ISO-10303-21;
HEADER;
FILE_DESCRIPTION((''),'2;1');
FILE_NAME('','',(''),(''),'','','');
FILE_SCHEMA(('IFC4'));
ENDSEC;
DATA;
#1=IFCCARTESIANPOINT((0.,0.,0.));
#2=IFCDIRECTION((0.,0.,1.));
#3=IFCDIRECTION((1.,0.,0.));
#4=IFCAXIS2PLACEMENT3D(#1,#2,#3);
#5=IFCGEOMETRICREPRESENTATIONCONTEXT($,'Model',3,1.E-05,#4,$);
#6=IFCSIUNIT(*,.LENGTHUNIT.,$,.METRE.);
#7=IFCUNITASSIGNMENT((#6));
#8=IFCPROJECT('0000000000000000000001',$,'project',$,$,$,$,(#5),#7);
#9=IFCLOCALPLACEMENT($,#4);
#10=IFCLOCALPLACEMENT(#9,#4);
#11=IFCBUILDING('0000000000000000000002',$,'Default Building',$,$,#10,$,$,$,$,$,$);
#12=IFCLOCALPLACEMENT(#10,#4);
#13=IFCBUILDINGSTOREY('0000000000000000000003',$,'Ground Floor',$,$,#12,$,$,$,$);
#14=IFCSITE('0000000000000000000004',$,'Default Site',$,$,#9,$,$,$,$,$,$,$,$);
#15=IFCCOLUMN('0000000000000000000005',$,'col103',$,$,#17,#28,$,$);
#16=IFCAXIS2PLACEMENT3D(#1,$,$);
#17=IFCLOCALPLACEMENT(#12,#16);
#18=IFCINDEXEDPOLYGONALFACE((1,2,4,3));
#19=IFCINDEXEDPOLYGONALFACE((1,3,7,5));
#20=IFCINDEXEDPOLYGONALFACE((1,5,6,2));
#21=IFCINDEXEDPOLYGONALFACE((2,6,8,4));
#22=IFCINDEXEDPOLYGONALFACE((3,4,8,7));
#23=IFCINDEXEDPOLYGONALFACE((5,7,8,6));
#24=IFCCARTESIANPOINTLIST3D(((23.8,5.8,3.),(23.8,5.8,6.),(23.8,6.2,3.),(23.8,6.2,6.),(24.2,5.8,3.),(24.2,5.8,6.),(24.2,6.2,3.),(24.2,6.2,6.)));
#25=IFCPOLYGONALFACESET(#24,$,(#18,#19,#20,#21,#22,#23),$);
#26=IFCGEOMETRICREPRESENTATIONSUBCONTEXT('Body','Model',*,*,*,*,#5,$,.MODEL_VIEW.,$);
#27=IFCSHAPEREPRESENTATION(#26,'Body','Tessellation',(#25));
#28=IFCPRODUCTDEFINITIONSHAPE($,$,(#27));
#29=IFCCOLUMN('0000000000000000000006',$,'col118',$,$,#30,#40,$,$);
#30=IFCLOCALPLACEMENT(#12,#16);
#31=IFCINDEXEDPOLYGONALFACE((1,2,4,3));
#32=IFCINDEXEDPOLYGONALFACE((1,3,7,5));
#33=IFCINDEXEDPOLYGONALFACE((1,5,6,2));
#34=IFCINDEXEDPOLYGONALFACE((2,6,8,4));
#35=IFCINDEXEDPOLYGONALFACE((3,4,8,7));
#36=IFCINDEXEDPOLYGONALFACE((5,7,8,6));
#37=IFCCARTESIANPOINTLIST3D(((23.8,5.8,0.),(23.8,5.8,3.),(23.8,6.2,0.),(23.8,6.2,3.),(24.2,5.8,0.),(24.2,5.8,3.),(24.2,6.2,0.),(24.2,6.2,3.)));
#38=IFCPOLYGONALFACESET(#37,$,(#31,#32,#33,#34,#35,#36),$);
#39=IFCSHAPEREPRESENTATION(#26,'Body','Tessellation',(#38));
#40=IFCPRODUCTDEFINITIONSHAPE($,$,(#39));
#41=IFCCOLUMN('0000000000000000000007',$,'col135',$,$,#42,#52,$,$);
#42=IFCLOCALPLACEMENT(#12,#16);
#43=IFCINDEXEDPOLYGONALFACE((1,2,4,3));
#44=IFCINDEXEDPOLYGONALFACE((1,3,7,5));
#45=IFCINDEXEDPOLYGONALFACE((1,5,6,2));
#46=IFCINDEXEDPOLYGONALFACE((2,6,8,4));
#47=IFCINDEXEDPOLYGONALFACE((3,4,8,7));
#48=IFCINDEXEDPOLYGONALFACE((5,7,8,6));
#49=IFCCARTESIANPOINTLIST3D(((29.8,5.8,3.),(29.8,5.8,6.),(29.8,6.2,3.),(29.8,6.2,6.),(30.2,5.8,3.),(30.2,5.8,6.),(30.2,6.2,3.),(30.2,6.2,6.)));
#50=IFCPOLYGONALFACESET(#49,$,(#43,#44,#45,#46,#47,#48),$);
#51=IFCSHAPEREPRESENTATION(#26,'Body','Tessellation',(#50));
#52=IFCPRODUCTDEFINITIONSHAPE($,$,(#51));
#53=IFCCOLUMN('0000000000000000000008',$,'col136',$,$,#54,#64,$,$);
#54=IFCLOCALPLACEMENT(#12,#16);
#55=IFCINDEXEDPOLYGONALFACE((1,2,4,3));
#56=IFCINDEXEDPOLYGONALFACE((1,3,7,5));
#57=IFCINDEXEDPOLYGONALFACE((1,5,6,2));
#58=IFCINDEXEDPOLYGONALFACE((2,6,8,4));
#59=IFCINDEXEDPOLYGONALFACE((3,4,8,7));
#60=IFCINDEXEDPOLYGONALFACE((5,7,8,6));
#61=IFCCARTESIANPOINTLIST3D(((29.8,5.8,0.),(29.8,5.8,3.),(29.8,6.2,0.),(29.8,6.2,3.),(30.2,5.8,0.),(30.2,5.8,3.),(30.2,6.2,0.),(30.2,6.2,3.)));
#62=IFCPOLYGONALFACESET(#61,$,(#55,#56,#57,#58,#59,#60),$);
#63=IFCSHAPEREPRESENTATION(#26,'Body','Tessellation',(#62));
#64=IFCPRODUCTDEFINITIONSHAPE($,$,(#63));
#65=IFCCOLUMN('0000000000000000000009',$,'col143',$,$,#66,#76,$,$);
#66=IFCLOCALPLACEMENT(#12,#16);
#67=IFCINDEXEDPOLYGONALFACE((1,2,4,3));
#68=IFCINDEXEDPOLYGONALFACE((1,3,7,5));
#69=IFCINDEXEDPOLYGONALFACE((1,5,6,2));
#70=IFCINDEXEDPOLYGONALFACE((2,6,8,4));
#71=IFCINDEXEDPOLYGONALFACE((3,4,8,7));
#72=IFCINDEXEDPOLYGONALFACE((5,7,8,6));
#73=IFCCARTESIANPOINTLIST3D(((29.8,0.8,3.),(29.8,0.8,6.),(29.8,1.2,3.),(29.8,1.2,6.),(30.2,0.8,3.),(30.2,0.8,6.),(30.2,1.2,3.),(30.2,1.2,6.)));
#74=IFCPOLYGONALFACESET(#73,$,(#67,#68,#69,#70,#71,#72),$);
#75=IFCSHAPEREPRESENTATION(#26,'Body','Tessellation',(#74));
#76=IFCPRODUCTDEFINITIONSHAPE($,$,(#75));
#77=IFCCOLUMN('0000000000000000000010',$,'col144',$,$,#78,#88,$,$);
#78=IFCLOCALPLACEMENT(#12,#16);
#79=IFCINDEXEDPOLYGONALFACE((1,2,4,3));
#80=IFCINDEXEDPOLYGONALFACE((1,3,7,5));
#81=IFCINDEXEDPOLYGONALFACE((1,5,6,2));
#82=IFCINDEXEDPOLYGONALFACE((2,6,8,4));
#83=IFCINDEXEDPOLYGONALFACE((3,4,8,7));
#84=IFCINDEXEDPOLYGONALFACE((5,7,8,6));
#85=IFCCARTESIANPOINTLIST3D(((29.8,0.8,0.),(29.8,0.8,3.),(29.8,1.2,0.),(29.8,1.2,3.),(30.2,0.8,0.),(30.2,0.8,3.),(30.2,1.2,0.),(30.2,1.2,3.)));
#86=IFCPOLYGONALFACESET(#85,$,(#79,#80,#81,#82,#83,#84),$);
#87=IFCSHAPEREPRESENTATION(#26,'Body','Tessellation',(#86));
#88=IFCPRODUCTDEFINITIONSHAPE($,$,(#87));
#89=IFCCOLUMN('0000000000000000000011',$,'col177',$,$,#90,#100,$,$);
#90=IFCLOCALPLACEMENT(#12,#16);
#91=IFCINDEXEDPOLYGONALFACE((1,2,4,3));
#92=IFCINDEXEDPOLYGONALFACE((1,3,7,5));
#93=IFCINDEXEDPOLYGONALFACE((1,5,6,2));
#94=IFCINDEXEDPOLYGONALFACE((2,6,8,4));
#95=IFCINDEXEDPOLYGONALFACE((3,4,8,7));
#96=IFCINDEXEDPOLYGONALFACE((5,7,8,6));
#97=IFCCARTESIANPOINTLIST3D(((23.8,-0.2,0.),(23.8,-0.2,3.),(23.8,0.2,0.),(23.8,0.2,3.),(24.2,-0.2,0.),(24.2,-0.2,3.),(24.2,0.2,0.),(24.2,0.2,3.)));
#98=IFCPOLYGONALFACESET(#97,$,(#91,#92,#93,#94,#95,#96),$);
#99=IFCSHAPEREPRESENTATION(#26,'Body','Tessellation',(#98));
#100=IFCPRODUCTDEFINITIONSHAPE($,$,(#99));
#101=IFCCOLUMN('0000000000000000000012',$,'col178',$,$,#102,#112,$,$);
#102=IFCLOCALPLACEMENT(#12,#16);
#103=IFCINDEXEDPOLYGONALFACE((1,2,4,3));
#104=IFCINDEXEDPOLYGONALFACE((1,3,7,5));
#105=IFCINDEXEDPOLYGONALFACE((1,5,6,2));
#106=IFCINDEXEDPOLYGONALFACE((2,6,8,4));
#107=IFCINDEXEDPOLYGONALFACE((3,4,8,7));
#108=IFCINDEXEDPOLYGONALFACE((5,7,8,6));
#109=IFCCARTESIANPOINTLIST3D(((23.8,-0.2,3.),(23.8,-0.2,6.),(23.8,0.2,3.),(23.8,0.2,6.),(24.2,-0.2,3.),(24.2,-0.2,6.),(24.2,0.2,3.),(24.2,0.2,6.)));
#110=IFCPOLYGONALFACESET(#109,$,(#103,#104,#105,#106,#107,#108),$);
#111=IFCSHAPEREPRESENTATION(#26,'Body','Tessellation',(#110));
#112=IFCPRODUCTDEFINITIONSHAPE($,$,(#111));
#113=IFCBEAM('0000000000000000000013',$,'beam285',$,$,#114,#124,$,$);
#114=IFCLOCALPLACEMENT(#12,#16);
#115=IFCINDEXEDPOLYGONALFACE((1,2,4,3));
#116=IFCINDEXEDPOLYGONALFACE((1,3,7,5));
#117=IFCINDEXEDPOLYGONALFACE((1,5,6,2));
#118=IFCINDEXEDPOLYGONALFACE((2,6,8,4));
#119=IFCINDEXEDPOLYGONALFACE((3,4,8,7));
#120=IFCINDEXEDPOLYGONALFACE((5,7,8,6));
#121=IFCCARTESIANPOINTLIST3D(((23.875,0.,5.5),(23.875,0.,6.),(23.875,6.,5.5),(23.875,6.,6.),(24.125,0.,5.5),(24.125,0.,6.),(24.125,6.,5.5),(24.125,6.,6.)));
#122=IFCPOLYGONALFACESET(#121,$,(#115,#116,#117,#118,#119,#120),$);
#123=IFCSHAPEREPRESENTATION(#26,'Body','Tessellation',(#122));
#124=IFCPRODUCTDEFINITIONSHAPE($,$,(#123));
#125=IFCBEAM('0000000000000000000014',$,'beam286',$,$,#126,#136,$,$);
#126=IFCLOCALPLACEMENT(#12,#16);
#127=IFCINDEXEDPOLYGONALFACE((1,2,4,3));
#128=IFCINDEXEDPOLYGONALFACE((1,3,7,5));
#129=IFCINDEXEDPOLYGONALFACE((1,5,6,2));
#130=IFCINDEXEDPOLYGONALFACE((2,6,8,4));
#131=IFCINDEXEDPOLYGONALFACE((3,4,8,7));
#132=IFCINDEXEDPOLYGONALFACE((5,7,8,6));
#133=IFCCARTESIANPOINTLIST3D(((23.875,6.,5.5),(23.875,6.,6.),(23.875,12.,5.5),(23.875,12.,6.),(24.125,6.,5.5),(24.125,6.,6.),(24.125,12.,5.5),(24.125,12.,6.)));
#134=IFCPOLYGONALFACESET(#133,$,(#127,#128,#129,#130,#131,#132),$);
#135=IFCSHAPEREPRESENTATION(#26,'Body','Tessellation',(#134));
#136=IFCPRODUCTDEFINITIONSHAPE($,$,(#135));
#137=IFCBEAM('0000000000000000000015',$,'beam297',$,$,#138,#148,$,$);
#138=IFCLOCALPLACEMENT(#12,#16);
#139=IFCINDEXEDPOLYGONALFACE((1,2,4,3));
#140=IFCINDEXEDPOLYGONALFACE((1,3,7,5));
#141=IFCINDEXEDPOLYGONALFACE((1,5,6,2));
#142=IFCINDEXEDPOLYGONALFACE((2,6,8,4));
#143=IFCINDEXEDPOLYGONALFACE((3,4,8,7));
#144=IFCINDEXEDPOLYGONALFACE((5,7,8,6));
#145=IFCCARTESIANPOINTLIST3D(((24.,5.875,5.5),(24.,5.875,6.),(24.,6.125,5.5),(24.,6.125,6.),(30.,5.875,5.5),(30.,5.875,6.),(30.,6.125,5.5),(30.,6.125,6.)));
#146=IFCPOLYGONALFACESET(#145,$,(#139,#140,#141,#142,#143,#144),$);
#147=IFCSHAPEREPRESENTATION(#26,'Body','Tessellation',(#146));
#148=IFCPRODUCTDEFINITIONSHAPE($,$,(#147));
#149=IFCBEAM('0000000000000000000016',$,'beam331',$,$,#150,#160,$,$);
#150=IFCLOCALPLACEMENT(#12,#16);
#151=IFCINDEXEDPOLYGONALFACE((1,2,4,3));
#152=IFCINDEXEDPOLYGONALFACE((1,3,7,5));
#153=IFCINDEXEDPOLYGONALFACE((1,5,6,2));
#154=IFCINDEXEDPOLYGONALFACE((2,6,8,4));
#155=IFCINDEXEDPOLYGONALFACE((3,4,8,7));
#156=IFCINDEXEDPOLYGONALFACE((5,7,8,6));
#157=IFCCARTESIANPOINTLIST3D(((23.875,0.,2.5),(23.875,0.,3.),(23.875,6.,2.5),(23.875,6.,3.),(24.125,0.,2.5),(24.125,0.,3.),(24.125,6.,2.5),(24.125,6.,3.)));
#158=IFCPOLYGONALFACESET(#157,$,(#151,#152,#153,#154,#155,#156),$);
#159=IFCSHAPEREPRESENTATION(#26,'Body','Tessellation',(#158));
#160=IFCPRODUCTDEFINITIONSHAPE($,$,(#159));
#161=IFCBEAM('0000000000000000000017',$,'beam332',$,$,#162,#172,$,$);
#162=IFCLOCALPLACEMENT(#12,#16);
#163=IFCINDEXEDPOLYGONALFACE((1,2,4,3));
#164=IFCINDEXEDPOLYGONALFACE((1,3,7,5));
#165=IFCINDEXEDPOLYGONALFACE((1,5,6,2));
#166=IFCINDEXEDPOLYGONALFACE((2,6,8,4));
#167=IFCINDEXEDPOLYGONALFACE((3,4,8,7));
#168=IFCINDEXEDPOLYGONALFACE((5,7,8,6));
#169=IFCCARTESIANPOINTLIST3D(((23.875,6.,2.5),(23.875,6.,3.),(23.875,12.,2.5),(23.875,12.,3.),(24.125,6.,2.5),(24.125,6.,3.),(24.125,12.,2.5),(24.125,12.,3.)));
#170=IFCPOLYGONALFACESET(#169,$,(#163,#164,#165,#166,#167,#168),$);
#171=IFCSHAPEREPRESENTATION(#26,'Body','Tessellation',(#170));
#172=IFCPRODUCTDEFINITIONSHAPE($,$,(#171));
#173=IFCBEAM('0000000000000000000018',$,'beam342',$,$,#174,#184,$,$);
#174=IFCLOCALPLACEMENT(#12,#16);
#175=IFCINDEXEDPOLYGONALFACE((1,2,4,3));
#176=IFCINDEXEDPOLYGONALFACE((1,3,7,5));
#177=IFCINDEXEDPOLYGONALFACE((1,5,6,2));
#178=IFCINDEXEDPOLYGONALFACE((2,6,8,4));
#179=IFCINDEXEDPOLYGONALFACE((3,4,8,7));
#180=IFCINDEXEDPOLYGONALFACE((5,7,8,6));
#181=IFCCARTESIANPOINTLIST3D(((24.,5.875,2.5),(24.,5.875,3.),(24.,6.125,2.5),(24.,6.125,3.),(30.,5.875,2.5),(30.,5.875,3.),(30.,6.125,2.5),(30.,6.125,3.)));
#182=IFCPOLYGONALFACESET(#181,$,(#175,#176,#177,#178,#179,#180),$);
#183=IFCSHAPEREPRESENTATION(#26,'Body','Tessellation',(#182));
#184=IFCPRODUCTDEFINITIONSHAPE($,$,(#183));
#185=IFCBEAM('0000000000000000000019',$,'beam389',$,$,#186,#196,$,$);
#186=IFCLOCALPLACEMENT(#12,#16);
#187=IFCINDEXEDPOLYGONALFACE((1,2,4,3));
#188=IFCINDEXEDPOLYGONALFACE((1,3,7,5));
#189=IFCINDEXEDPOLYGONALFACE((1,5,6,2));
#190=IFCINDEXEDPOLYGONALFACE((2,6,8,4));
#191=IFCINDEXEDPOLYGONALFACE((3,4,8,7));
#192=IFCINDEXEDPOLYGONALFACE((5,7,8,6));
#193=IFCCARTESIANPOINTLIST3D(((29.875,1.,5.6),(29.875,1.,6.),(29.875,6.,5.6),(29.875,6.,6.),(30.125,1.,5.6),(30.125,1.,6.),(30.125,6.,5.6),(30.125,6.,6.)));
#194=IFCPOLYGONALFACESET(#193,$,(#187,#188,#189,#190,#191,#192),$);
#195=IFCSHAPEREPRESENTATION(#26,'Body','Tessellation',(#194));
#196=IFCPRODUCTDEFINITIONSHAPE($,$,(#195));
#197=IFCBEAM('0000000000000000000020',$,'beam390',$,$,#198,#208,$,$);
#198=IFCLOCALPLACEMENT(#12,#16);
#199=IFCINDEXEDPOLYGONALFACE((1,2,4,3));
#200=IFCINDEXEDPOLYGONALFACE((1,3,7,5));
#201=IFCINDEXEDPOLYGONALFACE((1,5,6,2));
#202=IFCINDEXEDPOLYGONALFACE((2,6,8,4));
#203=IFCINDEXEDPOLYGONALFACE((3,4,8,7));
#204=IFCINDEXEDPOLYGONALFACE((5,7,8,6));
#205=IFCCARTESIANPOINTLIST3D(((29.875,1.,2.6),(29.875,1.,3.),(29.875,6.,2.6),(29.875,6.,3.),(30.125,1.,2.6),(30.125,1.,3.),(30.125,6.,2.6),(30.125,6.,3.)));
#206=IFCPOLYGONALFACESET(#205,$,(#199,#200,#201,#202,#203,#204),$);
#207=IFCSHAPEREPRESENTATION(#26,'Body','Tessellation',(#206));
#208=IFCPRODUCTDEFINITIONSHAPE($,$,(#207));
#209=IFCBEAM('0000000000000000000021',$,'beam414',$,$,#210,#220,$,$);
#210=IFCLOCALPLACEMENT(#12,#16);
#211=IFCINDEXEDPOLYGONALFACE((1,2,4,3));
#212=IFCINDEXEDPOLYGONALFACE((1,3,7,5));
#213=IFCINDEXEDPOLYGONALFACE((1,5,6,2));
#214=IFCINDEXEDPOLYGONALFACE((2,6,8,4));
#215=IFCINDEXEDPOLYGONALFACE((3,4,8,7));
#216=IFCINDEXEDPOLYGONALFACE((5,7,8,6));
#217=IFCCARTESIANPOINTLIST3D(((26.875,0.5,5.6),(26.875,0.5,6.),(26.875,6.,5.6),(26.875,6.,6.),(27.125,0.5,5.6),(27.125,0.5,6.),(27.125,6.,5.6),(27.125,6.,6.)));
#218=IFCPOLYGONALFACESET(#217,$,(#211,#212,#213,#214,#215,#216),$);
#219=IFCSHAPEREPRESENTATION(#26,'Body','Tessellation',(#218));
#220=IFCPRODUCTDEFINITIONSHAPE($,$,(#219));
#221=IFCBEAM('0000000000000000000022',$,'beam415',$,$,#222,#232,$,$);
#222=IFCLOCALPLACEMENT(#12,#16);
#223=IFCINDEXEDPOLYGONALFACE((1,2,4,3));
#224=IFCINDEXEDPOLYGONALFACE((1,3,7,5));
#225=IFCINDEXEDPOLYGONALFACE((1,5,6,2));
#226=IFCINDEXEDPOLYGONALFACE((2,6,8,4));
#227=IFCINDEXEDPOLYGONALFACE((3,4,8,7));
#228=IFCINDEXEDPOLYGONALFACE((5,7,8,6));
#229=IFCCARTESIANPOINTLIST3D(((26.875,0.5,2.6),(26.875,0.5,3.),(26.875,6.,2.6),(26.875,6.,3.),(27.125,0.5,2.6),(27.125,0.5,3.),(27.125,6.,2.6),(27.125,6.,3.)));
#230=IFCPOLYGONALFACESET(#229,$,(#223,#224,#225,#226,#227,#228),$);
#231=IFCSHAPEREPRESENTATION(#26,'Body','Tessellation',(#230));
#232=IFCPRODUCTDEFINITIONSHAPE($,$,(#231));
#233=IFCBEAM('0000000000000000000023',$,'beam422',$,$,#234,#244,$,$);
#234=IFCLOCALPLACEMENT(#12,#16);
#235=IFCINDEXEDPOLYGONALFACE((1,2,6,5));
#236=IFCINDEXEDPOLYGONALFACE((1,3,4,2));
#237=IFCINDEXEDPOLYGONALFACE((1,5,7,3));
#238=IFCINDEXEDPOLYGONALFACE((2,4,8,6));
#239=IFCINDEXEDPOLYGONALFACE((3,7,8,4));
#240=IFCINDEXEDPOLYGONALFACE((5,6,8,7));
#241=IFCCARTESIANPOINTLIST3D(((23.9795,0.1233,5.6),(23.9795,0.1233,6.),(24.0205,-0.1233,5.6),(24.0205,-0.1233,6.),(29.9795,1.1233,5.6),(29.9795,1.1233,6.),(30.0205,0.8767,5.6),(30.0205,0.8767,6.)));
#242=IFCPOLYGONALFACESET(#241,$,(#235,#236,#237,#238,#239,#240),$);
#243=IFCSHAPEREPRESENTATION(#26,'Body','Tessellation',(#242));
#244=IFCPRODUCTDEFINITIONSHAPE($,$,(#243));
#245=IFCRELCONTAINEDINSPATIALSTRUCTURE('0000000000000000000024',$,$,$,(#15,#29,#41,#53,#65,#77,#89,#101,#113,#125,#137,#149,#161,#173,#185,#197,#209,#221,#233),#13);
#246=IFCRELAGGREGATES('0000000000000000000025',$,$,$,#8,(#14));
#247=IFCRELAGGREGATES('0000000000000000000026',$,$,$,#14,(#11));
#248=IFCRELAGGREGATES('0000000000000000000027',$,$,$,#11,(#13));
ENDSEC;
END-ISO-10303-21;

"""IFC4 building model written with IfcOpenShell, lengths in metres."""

from ifc_helpers import new_model, si_unit, frame, origin_with_axes, place, context, subcontext, project, spatial, indexed_curve, outline, extrude, element, save


model = new_model("IFC4")

# Units and contexts
model_context = context("Model", 3, precision=1e-05, world=origin_with_axes())
body_context = subcontext(model_context, "Body", "Model", "MODEL_VIEW")
ifc_project = project(units=[si_unit("LENGTHUNIT", "METRE")], contexts=[model_context])

# Site, building, storey
site_placement = place(None, origin_with_axes())
site = spatial("IfcSite", under=ifc_project, at=site_placement, Name="Default Site")
building_placement = place(site_placement, origin_with_axes())
building = spatial("IfcBuilding", under=site, at=building_placement, Name="Default Building")
storey_placement = place(building_placement, origin_with_axes())
storey = spatial("IfcBuildingStorey", under=building, at=storey_placement, Name="Ground Floor")

# Columns
for number, where, z_axis, x_axis, name in (
    (1, (23.8, 5.8, 3.0), (0.0, 0.0, 1.0), (1.0, 0.0, 0.0), "col103"),
    (2, (23.8, 5.8, 0.0), (0.0, 0.0, 1.0), (1.0, 0.0, 0.0), "col118"),
    (3, (29.8, 5.8, 3.0), (0.0, 0.0, 1.0), (1.0, 0.0, 0.0), "col135"),
    (4, (29.8, 5.8, 0.0), (0.0, 0.0, 1.0), (1.0, 0.0, 0.0), "col136"),
    (5, (29.8, 0.8, 3.0), (0.0, 0.0, 1.0), (1.0, 0.0, 0.0), "col143"),
    (6, (29.8, 0.8, 0.0), (0.0, 0.0, 1.0), (1.0, 0.0, 0.0), "col144"),
    (7, (23.8, -0.2, 0.0), (0.0, 0.0, 1.0), (1.0, 0.0, 0.0), "col177"),
    (8, (23.8, -0.2, 3.0), (0.0, 0.0, 1.0), (1.0, 0.0, 0.0), "col178"),
):
    element("IfcColumn", number, at=place(storey_placement, frame(where, z_axis=z_axis, x_axis=x_axis)), inside=storey, Name=name, context=body_context, shape_type="SweptSolid", body=[
        extrude(outline(indexed_curve([(0.0, 0.0), (0.0, 0.4), (0.4, 0.4), (0.4, 0.0), (0.0, 0.0)], self_intersect=False)), origin_with_axes(), (0.0, 0.0, 1.0), 3.0),
    ])

# Beams
for number, where, z_axis, x_axis, name in (
    (9, (24.125, 0.0, 5.5), (0.0, 0.0, 1.0), (0.0, 1.0, 0.0), "beam285"),
    (10, (24.125, 6.0, 5.5), (0.0, 0.0, 1.0), (0.0, 1.0, 0.0), "beam286"),
    (11, (24.0, 5.875, 5.5), (0.0, 0.0, 1.0), (1.0, 0.0, 0.0), "beam297"),
    (12, (24.125, 0.0, 2.5), (0.0, 0.0, 1.0), (0.0, 1.0, 0.0), "beam331"),
    (13, (24.125, 6.0, 2.5), (0.0, 0.0, 1.0), (0.0, 1.0, 0.0), "beam332"),
    (14, (24.0, 5.875, 2.5), (0.0, 0.0, 1.0), (1.0, 0.0, 0.0), "beam342"),
):
    element("IfcBeam", number, at=place(storey_placement, frame(where, z_axis=z_axis, x_axis=x_axis)), inside=storey, Name=name, context=body_context, shape_type="SweptSolid", body=[
        extrude(outline(indexed_curve([(0.0, 0.0), (0.0, 0.25), (6.0, 0.25), (6.0, 0.0), (0.0, 0.0)], self_intersect=False)), origin_with_axes(), (0.0, 0.0, 1.0), 0.5),
    ])
for number, where, z_axis, x_axis, name in (
    (15, (29.875, 6.0, 5.6), (0.0, 0.0, 1.0), (0.0, -1.0, 0.0), "beam389"),
    (16, (29.875, 6.0, 2.6), (0.0, 0.0, 1.0), (0.0, -1.0, 0.0), "beam390"),
):
    element("IfcBeam", number, at=place(storey_placement, frame(where, z_axis=z_axis, x_axis=x_axis)), inside=storey, Name=name, context=body_context, shape_type="SweptSolid", body=[
        extrude(outline(indexed_curve([(0.0, 0.0), (0.0, 0.25), (5.0, 0.25), (5.0, 0.0), (0.0, 0.0)], self_intersect=False)), origin_with_axes(), (0.0, 0.0, 1.0), 0.4),
    ])
for number, where, z_axis, x_axis, name in (
    (17, (26.875, 6.0, 5.6), (0.0, 0.0, 1.0), (0.0, -1.0, 0.0), "beam414"),
    (18, (26.875, 6.0, 2.6), (0.0, 0.0, 1.0), (0.0, -1.0, 0.0), "beam415"),
):
    element("IfcBeam", number, at=place(storey_placement, frame(where, z_axis=z_axis, x_axis=x_axis)), inside=storey, Name=name, context=body_context, shape_type="SweptSolid", body=[
        extrude(outline(indexed_curve([(0.0, 0.0), (0.0, 0.25), (5.5, 0.25), (5.5, 0.0), (0.0, 0.0)], self_intersect=False)), origin_with_axes(), (0.0, 0.0, 1.0), 0.4),
    ])
for number, where, z_axis, x_axis, name in (
    (19, (24.0205, -0.1233, 5.6), (0.0, 0.0, 1.0), (0.986394, 0.164399, 0.0), "beam422"),
):
    element("IfcBeam", number, at=place(storey_placement, frame(where, z_axis=z_axis, x_axis=x_axis)), inside=storey, Name=name, context=body_context, shape_type="SweptSolid", body=[
        extrude(outline(indexed_curve([(0.0, 0.0), (0.0, 0.25), (6.0828, 0.25), (6.0828, 0.0), (0.0, 0.0)], self_intersect=False)), origin_with_axes(), (0.0, 0.0, 1.0), 0.4),
    ])

save(model, "model.ifc")
